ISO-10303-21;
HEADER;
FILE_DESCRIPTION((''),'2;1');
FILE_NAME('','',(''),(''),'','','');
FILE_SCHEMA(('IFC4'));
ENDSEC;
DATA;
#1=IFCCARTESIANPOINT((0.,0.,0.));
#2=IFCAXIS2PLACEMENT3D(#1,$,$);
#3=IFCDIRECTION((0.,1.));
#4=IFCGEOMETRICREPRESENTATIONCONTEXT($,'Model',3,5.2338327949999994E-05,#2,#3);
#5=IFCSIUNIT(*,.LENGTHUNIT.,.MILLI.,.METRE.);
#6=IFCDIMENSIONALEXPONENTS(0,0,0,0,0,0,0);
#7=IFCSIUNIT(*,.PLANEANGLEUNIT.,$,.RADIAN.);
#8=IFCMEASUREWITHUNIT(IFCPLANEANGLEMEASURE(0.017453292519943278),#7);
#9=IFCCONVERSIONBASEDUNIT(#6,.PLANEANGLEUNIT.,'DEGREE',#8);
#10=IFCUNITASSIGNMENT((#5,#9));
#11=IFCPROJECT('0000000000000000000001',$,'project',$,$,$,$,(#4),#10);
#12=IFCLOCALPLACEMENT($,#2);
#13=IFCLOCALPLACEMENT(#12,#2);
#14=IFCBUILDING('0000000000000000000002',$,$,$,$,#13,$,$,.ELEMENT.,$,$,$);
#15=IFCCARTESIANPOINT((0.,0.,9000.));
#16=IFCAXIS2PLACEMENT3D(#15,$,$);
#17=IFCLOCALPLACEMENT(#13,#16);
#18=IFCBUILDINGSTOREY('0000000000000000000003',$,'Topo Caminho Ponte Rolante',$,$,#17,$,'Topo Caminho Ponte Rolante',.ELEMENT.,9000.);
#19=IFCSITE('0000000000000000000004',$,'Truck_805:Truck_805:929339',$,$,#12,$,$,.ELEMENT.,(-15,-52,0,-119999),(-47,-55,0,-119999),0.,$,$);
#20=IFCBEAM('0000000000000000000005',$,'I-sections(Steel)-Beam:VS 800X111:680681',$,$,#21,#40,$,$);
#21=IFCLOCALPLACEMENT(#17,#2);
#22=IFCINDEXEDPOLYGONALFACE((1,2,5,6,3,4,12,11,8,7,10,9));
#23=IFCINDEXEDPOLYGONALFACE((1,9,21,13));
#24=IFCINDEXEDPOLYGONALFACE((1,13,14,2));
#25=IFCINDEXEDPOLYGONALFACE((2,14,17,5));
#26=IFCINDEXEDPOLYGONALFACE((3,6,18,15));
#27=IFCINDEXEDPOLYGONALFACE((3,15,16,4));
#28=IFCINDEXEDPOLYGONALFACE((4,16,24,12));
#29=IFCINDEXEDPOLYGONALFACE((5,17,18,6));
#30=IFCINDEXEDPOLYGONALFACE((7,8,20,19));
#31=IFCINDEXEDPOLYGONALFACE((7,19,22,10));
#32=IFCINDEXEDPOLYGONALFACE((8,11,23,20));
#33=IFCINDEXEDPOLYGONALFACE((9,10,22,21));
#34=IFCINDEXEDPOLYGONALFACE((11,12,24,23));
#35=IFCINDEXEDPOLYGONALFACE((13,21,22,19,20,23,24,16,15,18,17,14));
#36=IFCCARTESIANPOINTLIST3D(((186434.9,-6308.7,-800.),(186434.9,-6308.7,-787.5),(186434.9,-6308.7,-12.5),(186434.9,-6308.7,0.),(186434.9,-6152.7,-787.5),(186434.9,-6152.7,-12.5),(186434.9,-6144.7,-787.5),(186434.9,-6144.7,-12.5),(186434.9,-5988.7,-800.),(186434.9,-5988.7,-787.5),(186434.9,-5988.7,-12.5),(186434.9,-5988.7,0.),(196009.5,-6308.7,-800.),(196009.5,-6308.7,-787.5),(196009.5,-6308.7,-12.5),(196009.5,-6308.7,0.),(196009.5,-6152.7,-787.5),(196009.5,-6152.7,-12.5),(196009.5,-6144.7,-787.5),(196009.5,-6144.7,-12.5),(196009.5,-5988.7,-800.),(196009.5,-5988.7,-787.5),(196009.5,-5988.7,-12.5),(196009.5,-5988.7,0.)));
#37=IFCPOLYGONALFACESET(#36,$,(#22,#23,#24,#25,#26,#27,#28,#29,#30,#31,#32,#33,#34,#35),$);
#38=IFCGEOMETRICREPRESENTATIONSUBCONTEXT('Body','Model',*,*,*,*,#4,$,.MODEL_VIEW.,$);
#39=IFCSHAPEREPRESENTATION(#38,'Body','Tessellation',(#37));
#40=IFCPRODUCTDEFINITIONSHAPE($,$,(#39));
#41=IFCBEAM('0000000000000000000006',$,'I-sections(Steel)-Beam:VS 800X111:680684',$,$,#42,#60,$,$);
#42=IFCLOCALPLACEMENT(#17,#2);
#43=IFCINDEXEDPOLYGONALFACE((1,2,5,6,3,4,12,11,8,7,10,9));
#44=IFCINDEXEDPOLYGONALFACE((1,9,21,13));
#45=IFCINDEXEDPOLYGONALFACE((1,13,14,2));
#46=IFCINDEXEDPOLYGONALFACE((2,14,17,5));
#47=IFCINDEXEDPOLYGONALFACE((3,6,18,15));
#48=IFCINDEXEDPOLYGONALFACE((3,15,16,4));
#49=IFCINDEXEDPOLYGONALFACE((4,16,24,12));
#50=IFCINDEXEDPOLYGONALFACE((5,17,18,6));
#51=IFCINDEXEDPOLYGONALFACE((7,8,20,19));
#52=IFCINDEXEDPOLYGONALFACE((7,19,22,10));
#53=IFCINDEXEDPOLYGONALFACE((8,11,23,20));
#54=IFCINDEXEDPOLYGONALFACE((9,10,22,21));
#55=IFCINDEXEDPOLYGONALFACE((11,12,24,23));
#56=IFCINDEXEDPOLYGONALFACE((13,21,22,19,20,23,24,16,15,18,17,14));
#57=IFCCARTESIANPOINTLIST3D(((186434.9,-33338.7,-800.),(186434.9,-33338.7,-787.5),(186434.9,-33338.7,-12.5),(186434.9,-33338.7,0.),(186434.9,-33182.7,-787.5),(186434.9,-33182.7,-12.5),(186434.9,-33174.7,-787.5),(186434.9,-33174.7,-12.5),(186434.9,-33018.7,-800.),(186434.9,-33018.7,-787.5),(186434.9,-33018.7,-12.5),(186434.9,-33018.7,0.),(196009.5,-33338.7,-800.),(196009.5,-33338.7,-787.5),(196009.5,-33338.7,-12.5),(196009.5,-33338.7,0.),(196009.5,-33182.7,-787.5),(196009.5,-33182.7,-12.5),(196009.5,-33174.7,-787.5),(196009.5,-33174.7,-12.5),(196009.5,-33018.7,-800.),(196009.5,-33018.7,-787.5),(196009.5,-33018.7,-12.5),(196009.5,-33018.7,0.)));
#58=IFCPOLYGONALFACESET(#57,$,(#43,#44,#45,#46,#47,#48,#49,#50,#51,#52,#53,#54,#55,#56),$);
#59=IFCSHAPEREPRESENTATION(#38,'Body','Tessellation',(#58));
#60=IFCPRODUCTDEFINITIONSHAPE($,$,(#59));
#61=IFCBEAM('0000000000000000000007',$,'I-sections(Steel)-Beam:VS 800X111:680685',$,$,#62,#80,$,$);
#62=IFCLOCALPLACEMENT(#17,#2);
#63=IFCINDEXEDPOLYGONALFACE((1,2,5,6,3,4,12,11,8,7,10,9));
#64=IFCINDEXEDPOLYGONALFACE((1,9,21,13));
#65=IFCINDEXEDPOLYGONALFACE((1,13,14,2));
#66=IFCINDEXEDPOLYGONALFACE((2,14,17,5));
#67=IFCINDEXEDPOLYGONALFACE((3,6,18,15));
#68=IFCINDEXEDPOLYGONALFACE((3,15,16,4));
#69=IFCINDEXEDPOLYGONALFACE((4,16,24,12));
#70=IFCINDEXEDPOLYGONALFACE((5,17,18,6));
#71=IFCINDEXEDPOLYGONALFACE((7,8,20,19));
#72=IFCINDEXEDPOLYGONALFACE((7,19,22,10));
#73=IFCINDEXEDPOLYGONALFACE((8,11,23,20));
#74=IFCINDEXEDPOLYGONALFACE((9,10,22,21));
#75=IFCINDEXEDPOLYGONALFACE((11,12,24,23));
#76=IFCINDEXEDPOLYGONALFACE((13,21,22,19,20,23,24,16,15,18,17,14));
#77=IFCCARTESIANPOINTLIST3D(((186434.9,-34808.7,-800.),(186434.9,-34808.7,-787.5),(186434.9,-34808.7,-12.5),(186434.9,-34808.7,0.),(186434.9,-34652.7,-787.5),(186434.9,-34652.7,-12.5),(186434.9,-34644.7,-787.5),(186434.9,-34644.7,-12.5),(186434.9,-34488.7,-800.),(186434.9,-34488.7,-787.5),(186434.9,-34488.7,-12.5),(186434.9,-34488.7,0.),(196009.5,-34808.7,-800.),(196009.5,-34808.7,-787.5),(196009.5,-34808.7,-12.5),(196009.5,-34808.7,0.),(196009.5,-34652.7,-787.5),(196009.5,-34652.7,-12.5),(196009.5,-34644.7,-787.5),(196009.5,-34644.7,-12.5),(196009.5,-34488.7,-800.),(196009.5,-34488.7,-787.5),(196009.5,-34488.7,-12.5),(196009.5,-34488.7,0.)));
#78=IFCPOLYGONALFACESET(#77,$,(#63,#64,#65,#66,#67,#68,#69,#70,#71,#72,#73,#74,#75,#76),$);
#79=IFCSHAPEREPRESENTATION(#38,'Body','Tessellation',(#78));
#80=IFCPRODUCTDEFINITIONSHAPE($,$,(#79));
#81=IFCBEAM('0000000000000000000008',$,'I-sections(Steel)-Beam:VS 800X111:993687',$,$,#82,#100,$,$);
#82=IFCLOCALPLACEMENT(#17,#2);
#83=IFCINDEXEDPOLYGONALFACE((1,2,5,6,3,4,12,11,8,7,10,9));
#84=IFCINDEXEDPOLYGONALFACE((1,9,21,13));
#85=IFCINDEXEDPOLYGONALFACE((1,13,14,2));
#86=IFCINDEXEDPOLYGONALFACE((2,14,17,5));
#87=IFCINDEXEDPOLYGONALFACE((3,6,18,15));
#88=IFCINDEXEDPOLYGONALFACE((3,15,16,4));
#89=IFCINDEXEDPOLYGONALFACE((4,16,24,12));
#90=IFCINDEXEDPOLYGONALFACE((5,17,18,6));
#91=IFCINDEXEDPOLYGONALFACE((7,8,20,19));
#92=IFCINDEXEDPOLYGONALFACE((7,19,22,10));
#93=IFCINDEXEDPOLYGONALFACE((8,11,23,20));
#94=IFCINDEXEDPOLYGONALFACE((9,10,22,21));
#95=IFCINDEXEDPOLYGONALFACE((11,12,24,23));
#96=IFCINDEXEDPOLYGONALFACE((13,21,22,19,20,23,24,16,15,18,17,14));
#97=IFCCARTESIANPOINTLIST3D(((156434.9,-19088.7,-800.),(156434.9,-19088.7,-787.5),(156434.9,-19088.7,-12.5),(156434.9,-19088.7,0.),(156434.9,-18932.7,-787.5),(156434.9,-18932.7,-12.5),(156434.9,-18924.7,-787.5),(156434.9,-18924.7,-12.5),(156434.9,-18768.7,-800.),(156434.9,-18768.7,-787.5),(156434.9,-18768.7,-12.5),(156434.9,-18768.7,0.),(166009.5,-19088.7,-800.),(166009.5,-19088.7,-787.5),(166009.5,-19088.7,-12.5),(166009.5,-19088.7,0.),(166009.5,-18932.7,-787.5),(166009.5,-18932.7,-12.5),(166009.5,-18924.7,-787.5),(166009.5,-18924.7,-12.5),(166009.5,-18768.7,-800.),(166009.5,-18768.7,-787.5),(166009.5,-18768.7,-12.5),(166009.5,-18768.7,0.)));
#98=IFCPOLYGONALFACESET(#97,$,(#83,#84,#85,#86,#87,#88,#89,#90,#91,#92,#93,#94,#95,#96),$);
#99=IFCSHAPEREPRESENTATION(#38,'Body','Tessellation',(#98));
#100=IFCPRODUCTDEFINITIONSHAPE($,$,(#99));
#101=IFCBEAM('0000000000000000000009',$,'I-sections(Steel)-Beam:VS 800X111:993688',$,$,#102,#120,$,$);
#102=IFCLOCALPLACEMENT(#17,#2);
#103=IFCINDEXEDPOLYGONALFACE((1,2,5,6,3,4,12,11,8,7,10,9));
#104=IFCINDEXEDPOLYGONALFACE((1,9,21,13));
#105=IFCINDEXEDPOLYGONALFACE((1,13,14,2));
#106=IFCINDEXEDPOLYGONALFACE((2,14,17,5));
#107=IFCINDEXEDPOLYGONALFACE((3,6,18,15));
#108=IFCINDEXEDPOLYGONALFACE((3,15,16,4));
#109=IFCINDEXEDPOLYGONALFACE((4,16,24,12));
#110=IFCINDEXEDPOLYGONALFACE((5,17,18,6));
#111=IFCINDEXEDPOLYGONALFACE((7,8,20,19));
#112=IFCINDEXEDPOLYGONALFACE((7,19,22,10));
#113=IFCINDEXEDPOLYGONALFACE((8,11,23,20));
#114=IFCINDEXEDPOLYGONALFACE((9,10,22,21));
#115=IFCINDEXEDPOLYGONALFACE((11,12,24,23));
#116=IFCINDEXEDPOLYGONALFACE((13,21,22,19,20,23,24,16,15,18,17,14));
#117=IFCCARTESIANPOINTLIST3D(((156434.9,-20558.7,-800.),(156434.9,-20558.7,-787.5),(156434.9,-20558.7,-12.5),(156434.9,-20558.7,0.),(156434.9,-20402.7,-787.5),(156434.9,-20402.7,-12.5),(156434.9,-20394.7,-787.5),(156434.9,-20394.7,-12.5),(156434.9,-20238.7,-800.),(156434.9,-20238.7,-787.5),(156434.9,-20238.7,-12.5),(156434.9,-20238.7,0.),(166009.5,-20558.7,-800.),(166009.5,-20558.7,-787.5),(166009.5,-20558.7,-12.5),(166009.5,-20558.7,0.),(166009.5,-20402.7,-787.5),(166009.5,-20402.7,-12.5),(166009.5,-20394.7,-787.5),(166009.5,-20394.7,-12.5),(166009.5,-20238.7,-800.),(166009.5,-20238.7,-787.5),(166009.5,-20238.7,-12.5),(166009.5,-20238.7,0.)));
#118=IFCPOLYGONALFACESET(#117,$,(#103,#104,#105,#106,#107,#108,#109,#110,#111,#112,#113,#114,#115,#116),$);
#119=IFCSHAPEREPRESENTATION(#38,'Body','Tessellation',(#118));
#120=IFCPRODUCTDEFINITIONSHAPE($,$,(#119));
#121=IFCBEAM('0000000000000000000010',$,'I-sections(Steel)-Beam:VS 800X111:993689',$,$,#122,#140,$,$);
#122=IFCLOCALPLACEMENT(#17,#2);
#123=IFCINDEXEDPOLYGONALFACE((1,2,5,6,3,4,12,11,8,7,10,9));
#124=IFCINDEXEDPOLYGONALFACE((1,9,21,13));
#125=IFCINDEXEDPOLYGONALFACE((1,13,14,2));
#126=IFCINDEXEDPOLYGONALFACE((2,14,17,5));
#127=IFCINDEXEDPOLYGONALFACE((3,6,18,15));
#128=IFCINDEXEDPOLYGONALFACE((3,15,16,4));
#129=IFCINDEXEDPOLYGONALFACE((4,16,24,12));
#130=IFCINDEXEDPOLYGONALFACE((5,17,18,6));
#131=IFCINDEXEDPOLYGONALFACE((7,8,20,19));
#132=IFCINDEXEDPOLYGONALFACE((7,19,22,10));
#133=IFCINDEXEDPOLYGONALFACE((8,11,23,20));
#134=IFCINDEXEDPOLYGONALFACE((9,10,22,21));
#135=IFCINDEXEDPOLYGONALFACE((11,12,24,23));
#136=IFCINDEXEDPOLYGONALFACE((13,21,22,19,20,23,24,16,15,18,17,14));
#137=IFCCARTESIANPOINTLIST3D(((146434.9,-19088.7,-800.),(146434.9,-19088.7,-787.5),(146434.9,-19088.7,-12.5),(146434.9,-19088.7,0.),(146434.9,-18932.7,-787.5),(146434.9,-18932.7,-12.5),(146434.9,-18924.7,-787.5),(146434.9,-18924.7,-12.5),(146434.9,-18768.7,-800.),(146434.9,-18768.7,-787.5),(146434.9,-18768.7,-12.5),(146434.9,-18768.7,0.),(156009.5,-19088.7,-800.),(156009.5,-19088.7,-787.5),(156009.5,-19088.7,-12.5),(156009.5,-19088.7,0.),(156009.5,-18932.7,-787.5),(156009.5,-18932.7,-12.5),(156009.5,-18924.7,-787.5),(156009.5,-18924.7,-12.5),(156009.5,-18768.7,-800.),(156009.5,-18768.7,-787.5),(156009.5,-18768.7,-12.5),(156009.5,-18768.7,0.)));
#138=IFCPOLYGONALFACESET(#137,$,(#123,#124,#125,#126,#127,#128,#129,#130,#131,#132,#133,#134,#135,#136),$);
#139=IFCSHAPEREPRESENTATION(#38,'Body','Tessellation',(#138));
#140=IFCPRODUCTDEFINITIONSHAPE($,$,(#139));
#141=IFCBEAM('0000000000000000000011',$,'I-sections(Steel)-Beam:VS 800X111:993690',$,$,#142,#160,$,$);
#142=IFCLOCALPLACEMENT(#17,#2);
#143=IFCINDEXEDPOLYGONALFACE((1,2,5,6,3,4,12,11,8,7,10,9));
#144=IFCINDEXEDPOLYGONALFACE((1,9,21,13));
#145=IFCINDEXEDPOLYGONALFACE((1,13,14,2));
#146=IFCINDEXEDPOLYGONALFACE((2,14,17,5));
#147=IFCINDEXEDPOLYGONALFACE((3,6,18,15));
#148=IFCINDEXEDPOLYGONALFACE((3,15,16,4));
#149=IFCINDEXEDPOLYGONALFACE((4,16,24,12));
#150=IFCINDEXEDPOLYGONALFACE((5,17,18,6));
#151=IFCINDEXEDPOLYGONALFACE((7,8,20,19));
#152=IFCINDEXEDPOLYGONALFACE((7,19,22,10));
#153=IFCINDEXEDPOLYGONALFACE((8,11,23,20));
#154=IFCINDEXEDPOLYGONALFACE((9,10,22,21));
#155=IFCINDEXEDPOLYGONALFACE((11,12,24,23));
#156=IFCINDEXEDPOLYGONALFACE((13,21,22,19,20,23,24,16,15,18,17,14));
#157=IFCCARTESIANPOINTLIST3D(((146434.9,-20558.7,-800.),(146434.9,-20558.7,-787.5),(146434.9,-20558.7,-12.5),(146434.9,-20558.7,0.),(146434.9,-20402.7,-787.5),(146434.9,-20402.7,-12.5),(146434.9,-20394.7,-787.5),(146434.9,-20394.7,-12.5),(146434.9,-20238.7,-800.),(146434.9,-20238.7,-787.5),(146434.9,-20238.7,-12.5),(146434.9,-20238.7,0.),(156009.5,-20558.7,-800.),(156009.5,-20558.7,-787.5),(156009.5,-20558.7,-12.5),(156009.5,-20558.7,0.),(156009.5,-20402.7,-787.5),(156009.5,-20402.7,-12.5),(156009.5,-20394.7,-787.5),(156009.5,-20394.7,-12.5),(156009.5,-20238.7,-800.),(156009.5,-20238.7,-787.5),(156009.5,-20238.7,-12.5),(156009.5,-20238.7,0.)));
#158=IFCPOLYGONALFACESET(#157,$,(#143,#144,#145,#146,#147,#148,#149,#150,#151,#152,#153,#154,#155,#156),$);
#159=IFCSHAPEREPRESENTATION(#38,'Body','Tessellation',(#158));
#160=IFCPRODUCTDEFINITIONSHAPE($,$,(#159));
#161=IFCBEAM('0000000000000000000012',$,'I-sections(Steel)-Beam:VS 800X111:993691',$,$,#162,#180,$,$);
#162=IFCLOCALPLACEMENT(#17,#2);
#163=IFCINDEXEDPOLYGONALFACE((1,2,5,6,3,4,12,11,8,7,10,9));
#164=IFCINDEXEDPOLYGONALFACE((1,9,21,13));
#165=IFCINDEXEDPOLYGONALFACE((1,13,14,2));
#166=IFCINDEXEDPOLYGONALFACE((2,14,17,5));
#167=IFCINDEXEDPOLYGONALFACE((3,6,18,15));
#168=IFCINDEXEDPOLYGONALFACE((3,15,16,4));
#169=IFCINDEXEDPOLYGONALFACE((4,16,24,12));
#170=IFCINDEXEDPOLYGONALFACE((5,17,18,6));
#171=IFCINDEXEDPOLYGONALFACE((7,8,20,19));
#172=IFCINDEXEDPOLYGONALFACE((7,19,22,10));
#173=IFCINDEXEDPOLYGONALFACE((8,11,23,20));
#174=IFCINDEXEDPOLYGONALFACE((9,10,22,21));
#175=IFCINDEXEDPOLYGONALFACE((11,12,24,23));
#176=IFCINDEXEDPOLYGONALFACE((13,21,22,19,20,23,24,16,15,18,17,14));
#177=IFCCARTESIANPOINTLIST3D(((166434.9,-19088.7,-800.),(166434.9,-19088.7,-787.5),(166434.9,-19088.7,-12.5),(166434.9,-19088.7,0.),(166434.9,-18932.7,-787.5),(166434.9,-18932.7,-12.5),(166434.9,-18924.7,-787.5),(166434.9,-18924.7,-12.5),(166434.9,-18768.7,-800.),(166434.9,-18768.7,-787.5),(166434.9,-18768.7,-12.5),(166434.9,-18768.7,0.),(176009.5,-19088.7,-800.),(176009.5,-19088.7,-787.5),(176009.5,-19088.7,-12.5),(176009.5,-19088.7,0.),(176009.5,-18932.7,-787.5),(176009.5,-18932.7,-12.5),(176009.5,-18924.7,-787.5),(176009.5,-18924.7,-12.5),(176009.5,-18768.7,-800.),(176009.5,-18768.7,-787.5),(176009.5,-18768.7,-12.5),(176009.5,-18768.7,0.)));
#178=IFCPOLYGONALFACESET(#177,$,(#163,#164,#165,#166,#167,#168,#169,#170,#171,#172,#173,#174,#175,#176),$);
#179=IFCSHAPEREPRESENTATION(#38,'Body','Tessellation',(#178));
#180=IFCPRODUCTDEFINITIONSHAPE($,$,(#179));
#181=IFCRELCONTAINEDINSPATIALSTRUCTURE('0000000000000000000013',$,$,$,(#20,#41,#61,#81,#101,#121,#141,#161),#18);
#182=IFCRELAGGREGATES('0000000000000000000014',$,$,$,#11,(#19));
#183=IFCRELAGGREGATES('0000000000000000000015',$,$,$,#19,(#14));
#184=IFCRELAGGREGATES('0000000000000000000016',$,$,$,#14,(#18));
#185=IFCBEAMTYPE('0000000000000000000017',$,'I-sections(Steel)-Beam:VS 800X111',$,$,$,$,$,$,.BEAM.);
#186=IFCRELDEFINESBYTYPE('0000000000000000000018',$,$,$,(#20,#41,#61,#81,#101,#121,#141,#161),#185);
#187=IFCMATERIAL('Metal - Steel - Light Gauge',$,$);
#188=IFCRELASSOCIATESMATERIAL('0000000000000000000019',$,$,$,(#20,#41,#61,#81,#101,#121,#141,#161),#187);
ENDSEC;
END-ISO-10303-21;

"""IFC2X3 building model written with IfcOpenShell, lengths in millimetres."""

from ifc_helpers import new_model, entity, si_unit, converted_unit, direction, frame, frame_2d, origin, place, context, subcontext, project, spatial, polyline, i_section, outline, extrude, material, type_object, element, save


model = new_model("IFC2X3")

# Units and contexts
model_context = context("Model", 3, precision=5.2338327949999994e-05, world=origin(), true_north=direction((0.0, 1.0)))
body_context = subcontext(model_context, "Body", "Model", "MODEL_VIEW")
ifc_project = project(units=[si_unit("LENGTHUNIT", "METRE", prefix="MILLI"), converted_unit("PLANEANGLEUNIT", "DEGREE", entity("IfcPlaneAngleMeasure", 0.017453292519943278), si_unit("PLANEANGLEUNIT", "RADIAN"), dimensions=[0, 0, 0, 0, 0, 0, 0])], contexts=[model_context])

# Site, building, storey
site_placement = place(None, origin())
site = spatial("IfcSite", under=ifc_project, at=site_placement, Name="Truck_805:Truck_805:929339", CompositionType="ELEMENT", RefLatitude=(-15, -52, 0, -119999), RefLongitude=(-47, -55, 0, -119999), RefElevation=0.0)
building_placement = place(site_placement, origin())
building = spatial("IfcBuilding", under=site, at=building_placement, CompositionType="ELEMENT")
storey_placement = place(building_placement, frame((0.0, 0.0, 9000.0)))
storey = spatial("IfcBuildingStorey", under=building, at=storey_placement, Name="Topo Caminho Ponte Rolante", LongName="Topo Caminho Ponte Rolante", CompositionType="ELEMENT", Elevation=9000.0)

# Beams
ifc_material = material(Name="Metal - Steel - Light Gauge")
beam_type_1 = type_object("IfcBeamType", Name="I-sections(Steel)-Beam:VS 800X111", PredefinedType="BEAM")
beam_1_placement = place(storey_placement, frame((186222.2, -6148.7, 0.0)))
element("IfcBeam", 1, at=beam_1_placement, inside=storey, type_object=beam_type_1, material=ifc_material, Name="I-sections(Steel)-Beam:VS 800X111:680681", context=body_context, shape_type="SweptSolid", body=[
    extrude(outline(polyline([(387.5, -160.0), (400.0, -160.0), (400.0, 160.0), (387.5, 160.0), (387.5, 4.0), (-387.5, 4.0), (-387.5, 160.0), (-400.0, 160.0), (-400.0, -160.0), (-387.5, -160.0), (-387.5, -4.0), (387.5, -4.0), (387.5, -160.0)])), frame((212.7, 0.0, -400.0), z_axis=(1.0, 0.0, 0.0), x_axis=(0.0, 0.0, -1.0)), (0.0, 0.0, 1.0), 9574.6),
])
beam_2_placement = place(storey_placement, frame((186222.2, -33178.7, 0.0)))
element("IfcBeam", 2, at=beam_2_placement, inside=storey, type_object=beam_type_1, material=ifc_material, Name="I-sections(Steel)-Beam:VS 800X111:680684", context=body_context, shape_type="SweptSolid", body=[
    extrude(i_section(OverallWidth=320.0, OverallDepth=800.0, WebThickness=8.0, FlangeThickness=12.5, at=frame_2d((0.0, 0.0), x_axis=(0.0, 1.0))), frame((212.7, 0.0, -400.0), z_axis=(1.0, 0.0, 0.0), x_axis=(0.0, 0.0, -1.0)), (0.0, 0.0, 1.0), 9574.6),
])
beam_3_placement = place(storey_placement, frame((186222.2, -34648.7, 0.0)))
element("IfcBeam", 3, at=beam_3_placement, inside=storey, type_object=beam_type_1, material=ifc_material, Name="I-sections(Steel)-Beam:VS 800X111:680685", context=body_context, shape_type="SweptSolid", body=[
    extrude(outline(polyline([(387.5, -160.0), (400.0, -160.0), (400.0, 160.0), (387.5, 160.0), (387.5, 4.0), (-387.5, 4.0), (-387.5, 160.0), (-400.0, 160.0), (-400.0, -160.0), (-387.5, -160.0), (-387.5, -4.0), (387.5, -4.0), (387.5, -160.0)])), frame((212.7, 0.0, -400.0), z_axis=(1.0, 0.0, 0.0), x_axis=(0.0, 0.0, -1.0)), (0.0, 0.0, 1.0), 9574.6),
])
beam_4_placement = place(storey_placement, frame((156222.2, -18928.7, 0.0)))
element("IfcBeam", 4, at=beam_4_placement, inside=storey, type_object=beam_type_1, material=ifc_material, Name="I-sections(Steel)-Beam:VS 800X111:993687", context=body_context, shape_type="SweptSolid", body=[
    extrude(i_section(OverallWidth=320.0, OverallDepth=800.0, WebThickness=8.0, FlangeThickness=12.5, at=frame_2d((0.0, 0.0), x_axis=(0.0, 1.0))), frame((212.7, 0.0, -400.0), z_axis=(1.0, 0.0, 0.0), x_axis=(0.0, 0.0, -1.0)), (0.0, 0.0, 1.0), 9574.6),
])
beam_5_placement = place(storey_placement, frame((156222.2, -20398.7, 0.0)))
element("IfcBeam", 5, at=beam_5_placement, inside=storey, type_object=beam_type_1, material=ifc_material, Name="I-sections(Steel)-Beam:VS 800X111:993688", context=body_context, shape_type="SweptSolid", body=[
    extrude(outline(polyline([(387.5, -160.0), (400.0, -160.0), (400.0, 160.0), (387.5, 160.0), (387.5, 4.0), (-387.5, 4.0), (-387.5, 160.0), (-400.0, 160.0), (-400.0, -160.0), (-387.5, -160.0), (-387.5, -4.0), (387.5, -4.0), (387.5, -160.0)])), frame((212.7, 0.0, -400.0), z_axis=(1.0, 0.0, 0.0), x_axis=(0.0, 0.0, -1.0)), (0.0, 0.0, 1.0), 9574.6),
])
beam_6_placement = place(storey_placement, frame((146222.2, -18928.7, 0.0)))
element("IfcBeam", 6, at=beam_6_placement, inside=storey, type_object=beam_type_1, material=ifc_material, Name="I-sections(Steel)-Beam:VS 800X111:993689", context=body_context, shape_type="SweptSolid", body=[
    extrude(i_section(OverallWidth=320.0, OverallDepth=800.0, WebThickness=8.0, FlangeThickness=12.5, at=frame_2d((0.0, 0.0), x_axis=(0.0, 1.0))), frame((212.7, 0.0, -400.0), z_axis=(1.0, 0.0, 0.0), x_axis=(0.0, 0.0, -1.0)), (0.0, 0.0, 1.0), 9574.6),
])
beam_7_placement = place(storey_placement, frame((146222.2, -20398.7, 0.0)))
element("IfcBeam", 7, at=beam_7_placement, inside=storey, type_object=beam_type_1, material=ifc_material, Name="I-sections(Steel)-Beam:VS 800X111:993690", context=body_context, shape_type="SweptSolid", body=[
    extrude(outline(polyline([(387.5, -160.0), (400.0, -160.0), (400.0, 160.0), (387.5, 160.0), (387.5, 4.0), (-387.5, 4.0), (-387.5, 160.0), (-400.0, 160.0), (-400.0, -160.0), (-387.5, -160.0), (-387.5, -4.0), (387.5, -4.0), (387.5, -160.0)])), frame((212.7, 0.0, -400.0), z_axis=(1.0, 0.0, 0.0), x_axis=(0.0, 0.0, -1.0)), (0.0, 0.0, 1.0), 9574.6),
])
beam_8_placement = place(storey_placement, frame((166222.2, -18928.7, 0.0)))
element("IfcBeam", 8, at=beam_8_placement, inside=storey, type_object=beam_type_1, material=ifc_material, Name="I-sections(Steel)-Beam:VS 800X111:993691", context=body_context, shape_type="SweptSolid", body=[
    extrude(i_section(OverallWidth=320.0, OverallDepth=800.0, WebThickness=8.0, FlangeThickness=12.5, at=frame_2d((0.0, 0.0), x_axis=(0.0, 1.0))), frame((212.7, 0.0, -400.0), z_axis=(1.0, 0.0, 0.0), x_axis=(0.0, 0.0, -1.0)), (0.0, 0.0, 1.0), 9574.6),
])

save(model, "model.ifc")
